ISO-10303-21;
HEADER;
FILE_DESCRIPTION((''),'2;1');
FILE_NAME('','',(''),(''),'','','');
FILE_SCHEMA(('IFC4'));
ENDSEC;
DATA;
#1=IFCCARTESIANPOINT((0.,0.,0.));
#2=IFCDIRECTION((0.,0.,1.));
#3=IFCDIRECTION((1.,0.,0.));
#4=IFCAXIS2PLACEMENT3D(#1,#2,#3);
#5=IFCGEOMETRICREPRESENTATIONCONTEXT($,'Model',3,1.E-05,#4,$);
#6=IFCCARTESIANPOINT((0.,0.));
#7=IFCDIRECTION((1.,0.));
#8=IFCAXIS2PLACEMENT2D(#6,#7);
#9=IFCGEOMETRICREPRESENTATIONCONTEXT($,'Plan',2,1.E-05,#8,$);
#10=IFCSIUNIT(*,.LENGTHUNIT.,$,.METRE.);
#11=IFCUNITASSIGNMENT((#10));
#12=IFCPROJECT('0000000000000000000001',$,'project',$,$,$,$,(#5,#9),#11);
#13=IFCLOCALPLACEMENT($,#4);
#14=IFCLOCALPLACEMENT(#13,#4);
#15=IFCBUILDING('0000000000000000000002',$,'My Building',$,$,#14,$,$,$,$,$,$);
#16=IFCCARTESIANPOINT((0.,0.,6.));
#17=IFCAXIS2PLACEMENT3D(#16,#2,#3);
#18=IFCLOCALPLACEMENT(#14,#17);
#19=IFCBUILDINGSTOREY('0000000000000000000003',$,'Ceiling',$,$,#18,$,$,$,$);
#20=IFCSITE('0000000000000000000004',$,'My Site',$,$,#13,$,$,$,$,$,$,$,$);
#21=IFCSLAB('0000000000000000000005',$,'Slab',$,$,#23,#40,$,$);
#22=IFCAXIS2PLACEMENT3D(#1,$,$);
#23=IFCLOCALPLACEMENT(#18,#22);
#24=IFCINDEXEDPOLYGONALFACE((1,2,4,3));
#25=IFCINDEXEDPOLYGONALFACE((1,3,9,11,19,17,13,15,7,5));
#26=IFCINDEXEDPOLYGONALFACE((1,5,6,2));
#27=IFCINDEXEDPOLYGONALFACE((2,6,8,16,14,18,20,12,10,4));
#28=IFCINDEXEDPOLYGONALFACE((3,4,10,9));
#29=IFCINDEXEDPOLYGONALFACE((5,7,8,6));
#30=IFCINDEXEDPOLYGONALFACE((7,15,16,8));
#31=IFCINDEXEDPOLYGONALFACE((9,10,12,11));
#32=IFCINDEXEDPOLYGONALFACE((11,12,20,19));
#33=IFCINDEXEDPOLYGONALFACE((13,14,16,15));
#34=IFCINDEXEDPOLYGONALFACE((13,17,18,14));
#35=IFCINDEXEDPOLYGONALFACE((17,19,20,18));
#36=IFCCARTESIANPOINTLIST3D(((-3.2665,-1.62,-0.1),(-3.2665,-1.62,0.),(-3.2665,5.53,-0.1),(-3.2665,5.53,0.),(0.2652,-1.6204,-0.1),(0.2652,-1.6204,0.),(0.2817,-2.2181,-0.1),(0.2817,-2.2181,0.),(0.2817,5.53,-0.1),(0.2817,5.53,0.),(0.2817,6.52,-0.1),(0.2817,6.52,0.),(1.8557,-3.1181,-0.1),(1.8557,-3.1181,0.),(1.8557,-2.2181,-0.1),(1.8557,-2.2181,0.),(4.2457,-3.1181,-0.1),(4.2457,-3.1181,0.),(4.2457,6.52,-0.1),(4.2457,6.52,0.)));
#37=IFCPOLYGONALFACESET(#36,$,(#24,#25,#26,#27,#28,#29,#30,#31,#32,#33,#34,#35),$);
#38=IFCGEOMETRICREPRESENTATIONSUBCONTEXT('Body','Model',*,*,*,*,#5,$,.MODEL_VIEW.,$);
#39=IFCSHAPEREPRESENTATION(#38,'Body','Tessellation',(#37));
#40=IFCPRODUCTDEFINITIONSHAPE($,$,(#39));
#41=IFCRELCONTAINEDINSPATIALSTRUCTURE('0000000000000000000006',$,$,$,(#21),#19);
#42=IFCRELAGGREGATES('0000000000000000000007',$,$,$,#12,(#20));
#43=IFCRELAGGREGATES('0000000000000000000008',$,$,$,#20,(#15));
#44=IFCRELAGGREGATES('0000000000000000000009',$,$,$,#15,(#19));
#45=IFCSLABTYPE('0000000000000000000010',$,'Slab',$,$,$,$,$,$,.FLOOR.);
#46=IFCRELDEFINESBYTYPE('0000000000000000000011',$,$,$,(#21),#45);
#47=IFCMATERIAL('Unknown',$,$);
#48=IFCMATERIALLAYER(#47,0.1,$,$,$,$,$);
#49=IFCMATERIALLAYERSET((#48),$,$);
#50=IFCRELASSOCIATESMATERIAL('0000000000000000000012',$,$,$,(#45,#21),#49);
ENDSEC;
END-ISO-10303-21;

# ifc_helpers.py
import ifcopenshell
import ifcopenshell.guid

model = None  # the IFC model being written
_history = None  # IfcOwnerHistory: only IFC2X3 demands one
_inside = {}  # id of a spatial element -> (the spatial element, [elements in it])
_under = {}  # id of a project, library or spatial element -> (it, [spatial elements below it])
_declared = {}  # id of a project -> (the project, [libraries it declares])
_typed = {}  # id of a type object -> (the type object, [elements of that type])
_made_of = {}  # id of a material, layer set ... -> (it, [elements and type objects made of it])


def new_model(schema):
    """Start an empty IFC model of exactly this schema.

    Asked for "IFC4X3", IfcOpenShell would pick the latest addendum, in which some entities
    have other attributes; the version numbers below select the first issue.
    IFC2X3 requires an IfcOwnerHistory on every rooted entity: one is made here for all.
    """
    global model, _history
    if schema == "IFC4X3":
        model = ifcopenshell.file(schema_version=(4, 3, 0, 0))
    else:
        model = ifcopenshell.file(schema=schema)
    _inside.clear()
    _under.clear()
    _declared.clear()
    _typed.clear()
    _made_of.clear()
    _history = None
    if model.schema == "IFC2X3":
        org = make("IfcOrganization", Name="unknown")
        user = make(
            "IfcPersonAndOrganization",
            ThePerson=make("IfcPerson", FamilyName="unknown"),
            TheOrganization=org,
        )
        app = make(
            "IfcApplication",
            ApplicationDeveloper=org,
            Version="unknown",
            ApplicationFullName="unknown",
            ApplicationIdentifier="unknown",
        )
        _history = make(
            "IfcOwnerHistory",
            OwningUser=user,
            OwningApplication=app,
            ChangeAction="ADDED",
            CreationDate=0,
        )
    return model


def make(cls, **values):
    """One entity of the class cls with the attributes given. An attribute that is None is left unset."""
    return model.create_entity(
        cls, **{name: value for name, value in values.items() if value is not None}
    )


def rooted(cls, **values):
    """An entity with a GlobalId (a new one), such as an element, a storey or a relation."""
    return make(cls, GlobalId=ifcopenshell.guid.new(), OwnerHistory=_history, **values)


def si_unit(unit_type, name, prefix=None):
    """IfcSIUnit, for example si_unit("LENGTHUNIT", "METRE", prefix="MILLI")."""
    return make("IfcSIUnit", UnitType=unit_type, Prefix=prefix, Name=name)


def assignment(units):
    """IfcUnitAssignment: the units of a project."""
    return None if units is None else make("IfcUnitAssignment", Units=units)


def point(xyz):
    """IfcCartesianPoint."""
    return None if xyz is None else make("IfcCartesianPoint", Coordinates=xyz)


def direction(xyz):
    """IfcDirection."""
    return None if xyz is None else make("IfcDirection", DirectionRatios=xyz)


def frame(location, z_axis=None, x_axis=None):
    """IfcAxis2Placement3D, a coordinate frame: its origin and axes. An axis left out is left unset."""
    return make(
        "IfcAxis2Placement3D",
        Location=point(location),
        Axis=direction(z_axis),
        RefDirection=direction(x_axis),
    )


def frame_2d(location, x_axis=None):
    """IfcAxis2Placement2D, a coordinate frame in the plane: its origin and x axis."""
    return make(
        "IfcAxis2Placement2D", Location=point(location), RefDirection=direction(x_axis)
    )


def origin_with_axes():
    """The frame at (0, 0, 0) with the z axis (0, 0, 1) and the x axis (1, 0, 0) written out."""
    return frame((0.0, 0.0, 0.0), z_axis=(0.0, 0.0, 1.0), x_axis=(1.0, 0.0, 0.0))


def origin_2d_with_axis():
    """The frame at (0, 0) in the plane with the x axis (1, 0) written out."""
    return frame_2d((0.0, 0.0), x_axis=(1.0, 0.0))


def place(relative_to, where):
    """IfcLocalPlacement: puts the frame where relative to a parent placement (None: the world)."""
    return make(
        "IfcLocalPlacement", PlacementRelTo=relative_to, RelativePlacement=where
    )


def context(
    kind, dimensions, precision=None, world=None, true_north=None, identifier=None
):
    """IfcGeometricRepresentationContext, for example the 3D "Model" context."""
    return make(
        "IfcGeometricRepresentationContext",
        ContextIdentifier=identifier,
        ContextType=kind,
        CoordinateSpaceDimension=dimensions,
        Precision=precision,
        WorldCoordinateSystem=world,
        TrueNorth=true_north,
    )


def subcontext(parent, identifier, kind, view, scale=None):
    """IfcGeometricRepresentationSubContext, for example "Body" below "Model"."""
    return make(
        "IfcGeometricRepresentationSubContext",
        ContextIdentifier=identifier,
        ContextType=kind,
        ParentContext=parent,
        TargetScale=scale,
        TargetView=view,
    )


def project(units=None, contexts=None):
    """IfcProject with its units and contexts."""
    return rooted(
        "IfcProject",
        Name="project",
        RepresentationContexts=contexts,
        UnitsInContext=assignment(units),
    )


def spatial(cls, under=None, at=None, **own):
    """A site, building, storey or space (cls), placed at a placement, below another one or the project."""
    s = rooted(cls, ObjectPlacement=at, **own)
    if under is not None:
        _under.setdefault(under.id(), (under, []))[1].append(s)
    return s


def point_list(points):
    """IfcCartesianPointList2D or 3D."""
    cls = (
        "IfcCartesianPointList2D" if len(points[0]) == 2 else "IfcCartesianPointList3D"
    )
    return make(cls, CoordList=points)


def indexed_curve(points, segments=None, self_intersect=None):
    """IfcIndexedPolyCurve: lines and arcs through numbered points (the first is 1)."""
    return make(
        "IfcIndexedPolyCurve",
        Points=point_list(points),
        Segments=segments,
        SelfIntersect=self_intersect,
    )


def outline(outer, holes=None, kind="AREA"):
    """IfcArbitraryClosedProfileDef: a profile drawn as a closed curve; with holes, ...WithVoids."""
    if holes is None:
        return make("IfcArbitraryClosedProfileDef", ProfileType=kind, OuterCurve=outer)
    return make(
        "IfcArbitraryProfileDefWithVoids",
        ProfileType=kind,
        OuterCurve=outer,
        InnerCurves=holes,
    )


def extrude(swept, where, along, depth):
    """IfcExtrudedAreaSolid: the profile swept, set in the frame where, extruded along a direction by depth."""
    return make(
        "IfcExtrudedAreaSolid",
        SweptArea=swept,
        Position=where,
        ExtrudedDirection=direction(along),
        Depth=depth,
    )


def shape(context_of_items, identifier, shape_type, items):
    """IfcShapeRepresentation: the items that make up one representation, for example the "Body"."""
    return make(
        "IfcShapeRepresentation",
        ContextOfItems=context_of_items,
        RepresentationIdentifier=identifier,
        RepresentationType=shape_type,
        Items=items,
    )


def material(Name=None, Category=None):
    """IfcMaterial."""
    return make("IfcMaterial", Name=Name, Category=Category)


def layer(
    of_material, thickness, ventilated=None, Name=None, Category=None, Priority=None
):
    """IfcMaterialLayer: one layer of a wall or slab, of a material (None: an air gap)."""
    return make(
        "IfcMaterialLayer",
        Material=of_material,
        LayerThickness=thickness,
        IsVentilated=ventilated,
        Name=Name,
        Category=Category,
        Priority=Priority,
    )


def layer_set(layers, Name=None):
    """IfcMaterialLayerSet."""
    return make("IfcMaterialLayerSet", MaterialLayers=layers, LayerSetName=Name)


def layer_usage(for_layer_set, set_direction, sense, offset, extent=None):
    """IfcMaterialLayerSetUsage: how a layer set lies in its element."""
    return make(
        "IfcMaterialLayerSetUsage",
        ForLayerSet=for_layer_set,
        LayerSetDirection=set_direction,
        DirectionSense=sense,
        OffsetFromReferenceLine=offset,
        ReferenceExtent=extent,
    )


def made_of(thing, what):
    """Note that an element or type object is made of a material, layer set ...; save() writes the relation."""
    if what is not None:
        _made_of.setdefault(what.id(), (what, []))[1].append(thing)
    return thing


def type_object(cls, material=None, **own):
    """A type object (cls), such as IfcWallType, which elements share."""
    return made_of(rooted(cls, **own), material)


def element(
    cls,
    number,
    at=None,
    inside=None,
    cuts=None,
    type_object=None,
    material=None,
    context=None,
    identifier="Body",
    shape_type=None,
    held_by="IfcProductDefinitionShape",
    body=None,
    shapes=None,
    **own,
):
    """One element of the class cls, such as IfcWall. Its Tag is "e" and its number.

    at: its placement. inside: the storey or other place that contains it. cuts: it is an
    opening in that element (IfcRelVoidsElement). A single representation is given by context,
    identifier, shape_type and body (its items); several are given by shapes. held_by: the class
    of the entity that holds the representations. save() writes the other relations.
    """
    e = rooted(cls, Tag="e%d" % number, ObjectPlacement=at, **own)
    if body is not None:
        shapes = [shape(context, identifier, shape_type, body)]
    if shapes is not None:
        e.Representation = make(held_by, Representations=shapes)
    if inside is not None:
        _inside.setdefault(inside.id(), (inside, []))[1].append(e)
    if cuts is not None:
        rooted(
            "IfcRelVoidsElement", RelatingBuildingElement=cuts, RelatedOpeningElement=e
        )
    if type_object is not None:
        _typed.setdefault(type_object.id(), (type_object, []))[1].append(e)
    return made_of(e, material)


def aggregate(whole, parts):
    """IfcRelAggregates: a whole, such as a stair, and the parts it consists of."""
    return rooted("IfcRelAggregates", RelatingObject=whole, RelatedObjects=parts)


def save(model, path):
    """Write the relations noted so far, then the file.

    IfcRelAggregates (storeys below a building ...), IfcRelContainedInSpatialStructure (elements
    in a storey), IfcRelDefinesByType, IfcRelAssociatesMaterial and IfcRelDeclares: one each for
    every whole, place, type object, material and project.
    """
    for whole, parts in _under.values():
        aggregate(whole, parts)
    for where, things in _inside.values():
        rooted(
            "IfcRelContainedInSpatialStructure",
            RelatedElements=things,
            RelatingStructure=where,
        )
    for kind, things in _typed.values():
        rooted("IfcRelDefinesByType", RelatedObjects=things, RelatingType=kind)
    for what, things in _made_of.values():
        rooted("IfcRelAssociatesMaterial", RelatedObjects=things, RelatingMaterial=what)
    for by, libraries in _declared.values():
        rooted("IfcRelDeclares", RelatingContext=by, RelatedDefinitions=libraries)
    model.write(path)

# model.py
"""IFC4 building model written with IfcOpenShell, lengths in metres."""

from ifc_helpers import new_model, si_unit, frame, origin_with_axes, origin_2d_with_axis, place, context, subcontext, project, spatial, indexed_curve, outline, extrude, material, layer, layer_set, layer_usage, type_object, element, save


model = new_model("IFC4")

# Units and contexts
model_context = context("Model", 3, precision=1e-05, world=origin_with_axes())
plan_context = context("Plan", 2, precision=1e-05, world=origin_2d_with_axis())
body_context = subcontext(model_context, "Body", "Model", "MODEL_VIEW")
ifc_project = project(units=[si_unit("LENGTHUNIT", "METRE")], contexts=[model_context, plan_context])

# Site, building, storey
site_placement = place(None, origin_with_axes())
site = spatial("IfcSite", under=ifc_project, at=site_placement, Name="My Site")
building_placement = place(site_placement, origin_with_axes())
building = spatial("IfcBuilding", under=site, at=building_placement, Name="My Building")
storey_placement = place(building_placement, frame((0.0, 0.0, 6.0), z_axis=(0.0, 0.0, 1.0), x_axis=(1.0, 0.0, 0.0)))
storey = spatial("IfcBuildingStorey", under=building, at=storey_placement, Name="Ceiling")

# Slab
ifc_material = material(Name="Unknown")
ifc_layer = layer(ifc_material, 0.1)
ifc_layer_set = layer_set([ifc_layer])
ifc_layer_usage = layer_usage(ifc_layer_set, "AXIS3", "POSITIVE", -0.1)
slab_type = type_object("IfcSlabType", Name="Slab", PredefinedType="FLOOR", material=ifc_layer_set)
slab_placement = place(storey_placement, frame((4.2457, 6.52, 0.0), z_axis=(0.0, 0.0, 1.0), x_axis=(1.0, 0.0, 0.0)))
element("IfcSlab", 1, at=slab_placement, inside=storey, type_object=slab_type, material=ifc_layer_usage, Name="Slab", context=body_context, shape_type="SweptSolid", body=[
    extrude(outline(indexed_curve([(0.0, 0.0), (-3.964, 0.0), (-3.964, -0.99), (-7.5122, -0.99), (-7.5122, -8.14), (-3.9805, -8.1404), (-3.964, -8.7381), (-2.39, -8.7381), (-2.39, -9.6381), (0.0, -9.6381), (0.0, 0.0)])), frame((0.0, 0.0, -0.1), z_axis=(0.0, 0.0, 1.0), x_axis=(1.0, 0.0, 0.0)), (0.0, 0.0, 1.0), 0.1),
])

save(model, "model.ifc")
